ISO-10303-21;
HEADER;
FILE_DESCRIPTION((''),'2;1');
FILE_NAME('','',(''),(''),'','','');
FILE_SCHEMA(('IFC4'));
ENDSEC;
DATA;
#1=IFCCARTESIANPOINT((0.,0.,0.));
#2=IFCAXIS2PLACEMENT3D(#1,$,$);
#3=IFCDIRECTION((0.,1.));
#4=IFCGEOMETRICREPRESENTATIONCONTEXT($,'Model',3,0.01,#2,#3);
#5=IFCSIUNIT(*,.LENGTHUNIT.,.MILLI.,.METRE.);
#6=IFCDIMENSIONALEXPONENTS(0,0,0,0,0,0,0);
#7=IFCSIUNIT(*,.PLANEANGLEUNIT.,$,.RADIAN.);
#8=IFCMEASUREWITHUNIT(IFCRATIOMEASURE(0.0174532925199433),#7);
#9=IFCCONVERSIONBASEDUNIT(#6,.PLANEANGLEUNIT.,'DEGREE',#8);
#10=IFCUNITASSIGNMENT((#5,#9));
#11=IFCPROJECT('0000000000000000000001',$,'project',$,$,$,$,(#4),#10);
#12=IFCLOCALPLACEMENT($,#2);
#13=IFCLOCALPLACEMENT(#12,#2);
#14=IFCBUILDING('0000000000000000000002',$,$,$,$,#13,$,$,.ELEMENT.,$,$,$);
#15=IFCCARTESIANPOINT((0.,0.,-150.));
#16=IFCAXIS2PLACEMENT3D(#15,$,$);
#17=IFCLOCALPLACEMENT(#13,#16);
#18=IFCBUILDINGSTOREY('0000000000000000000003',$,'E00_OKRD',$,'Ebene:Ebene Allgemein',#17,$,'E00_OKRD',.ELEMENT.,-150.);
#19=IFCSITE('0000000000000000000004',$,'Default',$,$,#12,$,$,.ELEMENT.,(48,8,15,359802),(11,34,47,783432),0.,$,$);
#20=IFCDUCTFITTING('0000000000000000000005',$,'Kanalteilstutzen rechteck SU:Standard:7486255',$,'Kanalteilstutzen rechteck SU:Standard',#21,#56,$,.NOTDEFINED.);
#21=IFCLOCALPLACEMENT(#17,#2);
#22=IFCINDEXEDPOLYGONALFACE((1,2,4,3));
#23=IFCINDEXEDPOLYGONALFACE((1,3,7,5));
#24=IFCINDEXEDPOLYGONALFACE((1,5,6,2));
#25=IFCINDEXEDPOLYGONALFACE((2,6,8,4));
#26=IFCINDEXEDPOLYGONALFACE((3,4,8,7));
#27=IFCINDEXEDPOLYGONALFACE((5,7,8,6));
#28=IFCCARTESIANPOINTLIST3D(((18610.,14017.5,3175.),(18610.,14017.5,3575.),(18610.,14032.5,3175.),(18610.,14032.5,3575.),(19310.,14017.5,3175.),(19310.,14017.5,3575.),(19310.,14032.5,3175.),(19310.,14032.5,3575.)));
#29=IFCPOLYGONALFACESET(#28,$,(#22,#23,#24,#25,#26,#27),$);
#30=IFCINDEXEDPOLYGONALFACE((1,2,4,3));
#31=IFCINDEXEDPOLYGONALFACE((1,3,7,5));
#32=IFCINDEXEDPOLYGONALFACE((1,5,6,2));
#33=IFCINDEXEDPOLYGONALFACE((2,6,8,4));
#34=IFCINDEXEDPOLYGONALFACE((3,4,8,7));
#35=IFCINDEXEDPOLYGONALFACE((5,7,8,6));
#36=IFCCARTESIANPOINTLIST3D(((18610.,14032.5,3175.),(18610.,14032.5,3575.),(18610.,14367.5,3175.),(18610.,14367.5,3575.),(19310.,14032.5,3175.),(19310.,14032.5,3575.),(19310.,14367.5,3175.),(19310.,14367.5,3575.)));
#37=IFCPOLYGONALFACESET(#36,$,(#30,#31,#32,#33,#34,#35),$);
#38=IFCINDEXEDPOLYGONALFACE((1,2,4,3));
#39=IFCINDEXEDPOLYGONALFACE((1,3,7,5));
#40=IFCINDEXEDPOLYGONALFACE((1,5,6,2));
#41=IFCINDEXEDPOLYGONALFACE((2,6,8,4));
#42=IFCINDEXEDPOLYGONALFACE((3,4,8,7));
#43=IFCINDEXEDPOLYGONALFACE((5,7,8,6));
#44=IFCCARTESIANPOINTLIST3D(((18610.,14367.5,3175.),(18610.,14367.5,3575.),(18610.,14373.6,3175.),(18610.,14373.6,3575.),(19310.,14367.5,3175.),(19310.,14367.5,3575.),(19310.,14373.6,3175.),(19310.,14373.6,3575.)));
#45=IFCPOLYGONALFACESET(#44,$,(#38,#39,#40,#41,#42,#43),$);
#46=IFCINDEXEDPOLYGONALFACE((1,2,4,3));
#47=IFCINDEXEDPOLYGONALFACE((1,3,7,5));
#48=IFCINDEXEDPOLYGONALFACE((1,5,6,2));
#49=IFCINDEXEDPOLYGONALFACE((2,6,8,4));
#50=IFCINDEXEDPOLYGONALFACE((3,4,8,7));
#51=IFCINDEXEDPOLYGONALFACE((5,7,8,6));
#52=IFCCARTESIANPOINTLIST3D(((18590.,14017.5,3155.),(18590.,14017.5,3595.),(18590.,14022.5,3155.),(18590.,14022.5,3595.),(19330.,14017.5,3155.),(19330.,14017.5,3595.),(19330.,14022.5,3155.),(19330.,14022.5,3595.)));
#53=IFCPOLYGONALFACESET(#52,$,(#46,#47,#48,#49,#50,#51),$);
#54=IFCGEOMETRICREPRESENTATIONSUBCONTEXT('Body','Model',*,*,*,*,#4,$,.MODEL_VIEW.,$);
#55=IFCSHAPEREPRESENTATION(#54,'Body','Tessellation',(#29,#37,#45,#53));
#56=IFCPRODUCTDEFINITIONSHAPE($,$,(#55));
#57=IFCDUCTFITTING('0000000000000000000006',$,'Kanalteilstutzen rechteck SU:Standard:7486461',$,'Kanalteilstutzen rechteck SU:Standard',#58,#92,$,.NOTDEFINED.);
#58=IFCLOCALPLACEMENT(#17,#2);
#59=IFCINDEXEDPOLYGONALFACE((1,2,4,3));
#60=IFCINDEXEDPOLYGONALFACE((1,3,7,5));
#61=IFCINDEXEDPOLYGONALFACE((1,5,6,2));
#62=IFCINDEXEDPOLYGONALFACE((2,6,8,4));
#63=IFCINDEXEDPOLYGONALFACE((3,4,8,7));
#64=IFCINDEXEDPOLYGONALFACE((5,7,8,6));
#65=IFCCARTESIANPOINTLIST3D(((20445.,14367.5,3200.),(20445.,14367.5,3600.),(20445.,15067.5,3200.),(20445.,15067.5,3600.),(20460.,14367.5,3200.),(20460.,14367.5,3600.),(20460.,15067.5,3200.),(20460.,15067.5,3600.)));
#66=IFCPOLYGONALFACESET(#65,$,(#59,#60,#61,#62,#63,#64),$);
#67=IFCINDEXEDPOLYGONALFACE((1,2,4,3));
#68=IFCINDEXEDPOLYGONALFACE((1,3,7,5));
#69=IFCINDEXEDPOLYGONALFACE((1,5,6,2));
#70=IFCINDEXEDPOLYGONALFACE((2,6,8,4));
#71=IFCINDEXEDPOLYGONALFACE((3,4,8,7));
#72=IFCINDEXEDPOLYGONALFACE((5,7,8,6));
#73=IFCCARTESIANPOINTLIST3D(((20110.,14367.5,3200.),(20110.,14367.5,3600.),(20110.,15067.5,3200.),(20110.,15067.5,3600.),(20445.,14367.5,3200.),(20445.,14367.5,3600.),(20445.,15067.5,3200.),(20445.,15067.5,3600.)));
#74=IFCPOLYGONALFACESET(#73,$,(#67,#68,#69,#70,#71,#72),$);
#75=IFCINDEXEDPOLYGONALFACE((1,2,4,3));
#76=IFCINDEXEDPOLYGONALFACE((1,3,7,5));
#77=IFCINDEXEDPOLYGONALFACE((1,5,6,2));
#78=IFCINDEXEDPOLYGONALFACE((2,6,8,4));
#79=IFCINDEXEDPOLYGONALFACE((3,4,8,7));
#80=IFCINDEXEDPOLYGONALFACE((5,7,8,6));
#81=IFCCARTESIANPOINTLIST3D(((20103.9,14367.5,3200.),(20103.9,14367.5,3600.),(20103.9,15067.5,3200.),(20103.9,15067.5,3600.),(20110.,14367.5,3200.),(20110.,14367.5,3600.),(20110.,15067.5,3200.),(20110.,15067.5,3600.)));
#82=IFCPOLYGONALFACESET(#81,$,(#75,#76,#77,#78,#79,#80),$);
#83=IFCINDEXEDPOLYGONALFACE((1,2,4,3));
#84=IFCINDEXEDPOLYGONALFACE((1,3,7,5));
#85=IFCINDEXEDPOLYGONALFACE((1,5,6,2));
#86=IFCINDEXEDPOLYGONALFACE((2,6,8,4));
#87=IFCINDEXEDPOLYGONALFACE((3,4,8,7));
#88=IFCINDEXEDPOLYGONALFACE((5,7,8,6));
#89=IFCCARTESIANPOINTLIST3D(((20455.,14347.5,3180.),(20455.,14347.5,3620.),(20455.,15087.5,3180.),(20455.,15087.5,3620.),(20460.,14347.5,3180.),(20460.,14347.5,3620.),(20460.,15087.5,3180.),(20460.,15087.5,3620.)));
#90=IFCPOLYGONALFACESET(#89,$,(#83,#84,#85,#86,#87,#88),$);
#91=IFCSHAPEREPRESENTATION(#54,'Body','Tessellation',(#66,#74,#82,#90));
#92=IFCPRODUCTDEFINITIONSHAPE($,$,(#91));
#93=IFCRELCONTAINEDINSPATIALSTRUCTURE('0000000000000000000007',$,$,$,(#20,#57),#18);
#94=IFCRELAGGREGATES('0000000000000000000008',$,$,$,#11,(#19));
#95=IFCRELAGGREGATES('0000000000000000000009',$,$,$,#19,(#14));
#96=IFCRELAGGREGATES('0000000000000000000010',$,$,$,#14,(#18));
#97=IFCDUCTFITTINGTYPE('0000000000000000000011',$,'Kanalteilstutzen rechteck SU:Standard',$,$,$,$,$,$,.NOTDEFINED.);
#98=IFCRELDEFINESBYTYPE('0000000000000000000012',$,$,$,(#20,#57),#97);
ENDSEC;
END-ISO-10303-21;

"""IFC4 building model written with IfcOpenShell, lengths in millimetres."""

from ifc_helpers import new_model, entity, si_unit, converted_unit, direction, frame, frame_2d, origin, place, context, subcontext, project, spatial, rectangle, extrude, source, transform, mapped, type_object, type_shapes, element, save


model = new_model("IFC4")

# Units and contexts
model_context = context("Model", 3, precision=0.01, world=origin(), true_north=direction((0.0, 1.0)))
body_context = subcontext(model_context, "Body", "Model", "MODEL_VIEW")
ifc_project = project(units=[si_unit("LENGTHUNIT", "METRE", prefix="MILLI"), converted_unit("PLANEANGLEUNIT", "DEGREE", entity("IfcRatioMeasure", 0.0174532925199433), si_unit("PLANEANGLEUNIT", "RADIAN"), dimensions=[0, 0, 0, 0, 0, 0, 0])], contexts=[model_context])

# Site, building, storey
site_placement = place(None, origin())
site = spatial("IfcSite", under=ifc_project, at=site_placement, Name="Default", CompositionType="ELEMENT", RefLatitude=(48, 8, 15, 359802), RefLongitude=(11, 34, 47, 783432), RefElevation=0.0)
building_placement = place(site_placement, origin())
building = spatial("IfcBuilding", under=site, at=building_placement, CompositionType="ELEMENT")
storey_placement = place(building_placement, frame((0.0, 0.0, -150.0)))
storey = spatial("IfcBuildingStorey", under=building, at=storey_placement, Name="E00_OKRD", ObjectType="Ebene:Ebene Allgemein", LongName="E00_OKRD", CompositionType="ELEMENT", Elevation=-150.0)

# Duct fittings
duct_fitting_type_1 = type_object("IfcDuctFittingType", Name="Kanalteilstutzen rechteck SU:Standard", PredefinedType="NOTDEFINED")
shared_shape_1 = source(origin(), body_context, "Body", "SweptSolid", [
    extrude(rectangle(XDim=15.0, YDim=400.0, at=frame_2d((0.0, 0.0), x_axis=(1.0, 0.0))), frame((342.5, 0.0, -350.0)), (0.0, 0.0, 1.0), 700.0),
    extrude(rectangle(XDim=335.0, YDim=400.0, at=frame_2d((0.0, 0.0), x_axis=(1.0, 0.0))), frame((167.5, 0.0, -350.0)), (0.0, 0.0, 1.0), 700.0),
    extrude(rectangle(XDim=6.1, YDim=400.0, at=frame_2d((0.0, 0.0), x_axis=(1.0, 0.0))), frame((-3.0, 0.0, -350.0)), (0.0, 0.0, 1.0), 700.0),
    extrude(rectangle(XDim=5.0, YDim=440.0, at=frame_2d((0.0, 0.0), x_axis=(1.0, 0.0))), frame((347.5, 0.0, -370.0)), (0.0, 0.0, 1.0), 740.0),
])
type_shapes(duct_fitting_type_1, [shared_shape_1])
for number, where, z_axis, x_axis, name in (
    (1, (18960.0, 14367.5, 3375.0), (-1.0, 0.0, 0.0), (0.0, -1.0, 0.0), "Kanalteilstutzen rechteck SU:Standard:7486255"),
    (2, (20110.0, 14717.5, 3400.0), (0.0, -1.0, 0.0), (1.0, 0.0, 0.0), "Kanalteilstutzen rechteck SU:Standard:7486461"),
):
    element("IfcDuctFitting", number, at=place(storey_placement, frame(where, z_axis=z_axis, x_axis=x_axis)), inside=storey, type_object=duct_fitting_type_1, Name=name, ObjectType="Kanalteilstutzen rechteck SU:Standard", PredefinedType="NOTDEFINED", context=body_context, shape_type="MappedRepresentation", body=[
        mapped(shared_shape_1, transform((0.0, 0.0, 0.0), scale=1.0)),
    ])

save(model, "model.ifc")
